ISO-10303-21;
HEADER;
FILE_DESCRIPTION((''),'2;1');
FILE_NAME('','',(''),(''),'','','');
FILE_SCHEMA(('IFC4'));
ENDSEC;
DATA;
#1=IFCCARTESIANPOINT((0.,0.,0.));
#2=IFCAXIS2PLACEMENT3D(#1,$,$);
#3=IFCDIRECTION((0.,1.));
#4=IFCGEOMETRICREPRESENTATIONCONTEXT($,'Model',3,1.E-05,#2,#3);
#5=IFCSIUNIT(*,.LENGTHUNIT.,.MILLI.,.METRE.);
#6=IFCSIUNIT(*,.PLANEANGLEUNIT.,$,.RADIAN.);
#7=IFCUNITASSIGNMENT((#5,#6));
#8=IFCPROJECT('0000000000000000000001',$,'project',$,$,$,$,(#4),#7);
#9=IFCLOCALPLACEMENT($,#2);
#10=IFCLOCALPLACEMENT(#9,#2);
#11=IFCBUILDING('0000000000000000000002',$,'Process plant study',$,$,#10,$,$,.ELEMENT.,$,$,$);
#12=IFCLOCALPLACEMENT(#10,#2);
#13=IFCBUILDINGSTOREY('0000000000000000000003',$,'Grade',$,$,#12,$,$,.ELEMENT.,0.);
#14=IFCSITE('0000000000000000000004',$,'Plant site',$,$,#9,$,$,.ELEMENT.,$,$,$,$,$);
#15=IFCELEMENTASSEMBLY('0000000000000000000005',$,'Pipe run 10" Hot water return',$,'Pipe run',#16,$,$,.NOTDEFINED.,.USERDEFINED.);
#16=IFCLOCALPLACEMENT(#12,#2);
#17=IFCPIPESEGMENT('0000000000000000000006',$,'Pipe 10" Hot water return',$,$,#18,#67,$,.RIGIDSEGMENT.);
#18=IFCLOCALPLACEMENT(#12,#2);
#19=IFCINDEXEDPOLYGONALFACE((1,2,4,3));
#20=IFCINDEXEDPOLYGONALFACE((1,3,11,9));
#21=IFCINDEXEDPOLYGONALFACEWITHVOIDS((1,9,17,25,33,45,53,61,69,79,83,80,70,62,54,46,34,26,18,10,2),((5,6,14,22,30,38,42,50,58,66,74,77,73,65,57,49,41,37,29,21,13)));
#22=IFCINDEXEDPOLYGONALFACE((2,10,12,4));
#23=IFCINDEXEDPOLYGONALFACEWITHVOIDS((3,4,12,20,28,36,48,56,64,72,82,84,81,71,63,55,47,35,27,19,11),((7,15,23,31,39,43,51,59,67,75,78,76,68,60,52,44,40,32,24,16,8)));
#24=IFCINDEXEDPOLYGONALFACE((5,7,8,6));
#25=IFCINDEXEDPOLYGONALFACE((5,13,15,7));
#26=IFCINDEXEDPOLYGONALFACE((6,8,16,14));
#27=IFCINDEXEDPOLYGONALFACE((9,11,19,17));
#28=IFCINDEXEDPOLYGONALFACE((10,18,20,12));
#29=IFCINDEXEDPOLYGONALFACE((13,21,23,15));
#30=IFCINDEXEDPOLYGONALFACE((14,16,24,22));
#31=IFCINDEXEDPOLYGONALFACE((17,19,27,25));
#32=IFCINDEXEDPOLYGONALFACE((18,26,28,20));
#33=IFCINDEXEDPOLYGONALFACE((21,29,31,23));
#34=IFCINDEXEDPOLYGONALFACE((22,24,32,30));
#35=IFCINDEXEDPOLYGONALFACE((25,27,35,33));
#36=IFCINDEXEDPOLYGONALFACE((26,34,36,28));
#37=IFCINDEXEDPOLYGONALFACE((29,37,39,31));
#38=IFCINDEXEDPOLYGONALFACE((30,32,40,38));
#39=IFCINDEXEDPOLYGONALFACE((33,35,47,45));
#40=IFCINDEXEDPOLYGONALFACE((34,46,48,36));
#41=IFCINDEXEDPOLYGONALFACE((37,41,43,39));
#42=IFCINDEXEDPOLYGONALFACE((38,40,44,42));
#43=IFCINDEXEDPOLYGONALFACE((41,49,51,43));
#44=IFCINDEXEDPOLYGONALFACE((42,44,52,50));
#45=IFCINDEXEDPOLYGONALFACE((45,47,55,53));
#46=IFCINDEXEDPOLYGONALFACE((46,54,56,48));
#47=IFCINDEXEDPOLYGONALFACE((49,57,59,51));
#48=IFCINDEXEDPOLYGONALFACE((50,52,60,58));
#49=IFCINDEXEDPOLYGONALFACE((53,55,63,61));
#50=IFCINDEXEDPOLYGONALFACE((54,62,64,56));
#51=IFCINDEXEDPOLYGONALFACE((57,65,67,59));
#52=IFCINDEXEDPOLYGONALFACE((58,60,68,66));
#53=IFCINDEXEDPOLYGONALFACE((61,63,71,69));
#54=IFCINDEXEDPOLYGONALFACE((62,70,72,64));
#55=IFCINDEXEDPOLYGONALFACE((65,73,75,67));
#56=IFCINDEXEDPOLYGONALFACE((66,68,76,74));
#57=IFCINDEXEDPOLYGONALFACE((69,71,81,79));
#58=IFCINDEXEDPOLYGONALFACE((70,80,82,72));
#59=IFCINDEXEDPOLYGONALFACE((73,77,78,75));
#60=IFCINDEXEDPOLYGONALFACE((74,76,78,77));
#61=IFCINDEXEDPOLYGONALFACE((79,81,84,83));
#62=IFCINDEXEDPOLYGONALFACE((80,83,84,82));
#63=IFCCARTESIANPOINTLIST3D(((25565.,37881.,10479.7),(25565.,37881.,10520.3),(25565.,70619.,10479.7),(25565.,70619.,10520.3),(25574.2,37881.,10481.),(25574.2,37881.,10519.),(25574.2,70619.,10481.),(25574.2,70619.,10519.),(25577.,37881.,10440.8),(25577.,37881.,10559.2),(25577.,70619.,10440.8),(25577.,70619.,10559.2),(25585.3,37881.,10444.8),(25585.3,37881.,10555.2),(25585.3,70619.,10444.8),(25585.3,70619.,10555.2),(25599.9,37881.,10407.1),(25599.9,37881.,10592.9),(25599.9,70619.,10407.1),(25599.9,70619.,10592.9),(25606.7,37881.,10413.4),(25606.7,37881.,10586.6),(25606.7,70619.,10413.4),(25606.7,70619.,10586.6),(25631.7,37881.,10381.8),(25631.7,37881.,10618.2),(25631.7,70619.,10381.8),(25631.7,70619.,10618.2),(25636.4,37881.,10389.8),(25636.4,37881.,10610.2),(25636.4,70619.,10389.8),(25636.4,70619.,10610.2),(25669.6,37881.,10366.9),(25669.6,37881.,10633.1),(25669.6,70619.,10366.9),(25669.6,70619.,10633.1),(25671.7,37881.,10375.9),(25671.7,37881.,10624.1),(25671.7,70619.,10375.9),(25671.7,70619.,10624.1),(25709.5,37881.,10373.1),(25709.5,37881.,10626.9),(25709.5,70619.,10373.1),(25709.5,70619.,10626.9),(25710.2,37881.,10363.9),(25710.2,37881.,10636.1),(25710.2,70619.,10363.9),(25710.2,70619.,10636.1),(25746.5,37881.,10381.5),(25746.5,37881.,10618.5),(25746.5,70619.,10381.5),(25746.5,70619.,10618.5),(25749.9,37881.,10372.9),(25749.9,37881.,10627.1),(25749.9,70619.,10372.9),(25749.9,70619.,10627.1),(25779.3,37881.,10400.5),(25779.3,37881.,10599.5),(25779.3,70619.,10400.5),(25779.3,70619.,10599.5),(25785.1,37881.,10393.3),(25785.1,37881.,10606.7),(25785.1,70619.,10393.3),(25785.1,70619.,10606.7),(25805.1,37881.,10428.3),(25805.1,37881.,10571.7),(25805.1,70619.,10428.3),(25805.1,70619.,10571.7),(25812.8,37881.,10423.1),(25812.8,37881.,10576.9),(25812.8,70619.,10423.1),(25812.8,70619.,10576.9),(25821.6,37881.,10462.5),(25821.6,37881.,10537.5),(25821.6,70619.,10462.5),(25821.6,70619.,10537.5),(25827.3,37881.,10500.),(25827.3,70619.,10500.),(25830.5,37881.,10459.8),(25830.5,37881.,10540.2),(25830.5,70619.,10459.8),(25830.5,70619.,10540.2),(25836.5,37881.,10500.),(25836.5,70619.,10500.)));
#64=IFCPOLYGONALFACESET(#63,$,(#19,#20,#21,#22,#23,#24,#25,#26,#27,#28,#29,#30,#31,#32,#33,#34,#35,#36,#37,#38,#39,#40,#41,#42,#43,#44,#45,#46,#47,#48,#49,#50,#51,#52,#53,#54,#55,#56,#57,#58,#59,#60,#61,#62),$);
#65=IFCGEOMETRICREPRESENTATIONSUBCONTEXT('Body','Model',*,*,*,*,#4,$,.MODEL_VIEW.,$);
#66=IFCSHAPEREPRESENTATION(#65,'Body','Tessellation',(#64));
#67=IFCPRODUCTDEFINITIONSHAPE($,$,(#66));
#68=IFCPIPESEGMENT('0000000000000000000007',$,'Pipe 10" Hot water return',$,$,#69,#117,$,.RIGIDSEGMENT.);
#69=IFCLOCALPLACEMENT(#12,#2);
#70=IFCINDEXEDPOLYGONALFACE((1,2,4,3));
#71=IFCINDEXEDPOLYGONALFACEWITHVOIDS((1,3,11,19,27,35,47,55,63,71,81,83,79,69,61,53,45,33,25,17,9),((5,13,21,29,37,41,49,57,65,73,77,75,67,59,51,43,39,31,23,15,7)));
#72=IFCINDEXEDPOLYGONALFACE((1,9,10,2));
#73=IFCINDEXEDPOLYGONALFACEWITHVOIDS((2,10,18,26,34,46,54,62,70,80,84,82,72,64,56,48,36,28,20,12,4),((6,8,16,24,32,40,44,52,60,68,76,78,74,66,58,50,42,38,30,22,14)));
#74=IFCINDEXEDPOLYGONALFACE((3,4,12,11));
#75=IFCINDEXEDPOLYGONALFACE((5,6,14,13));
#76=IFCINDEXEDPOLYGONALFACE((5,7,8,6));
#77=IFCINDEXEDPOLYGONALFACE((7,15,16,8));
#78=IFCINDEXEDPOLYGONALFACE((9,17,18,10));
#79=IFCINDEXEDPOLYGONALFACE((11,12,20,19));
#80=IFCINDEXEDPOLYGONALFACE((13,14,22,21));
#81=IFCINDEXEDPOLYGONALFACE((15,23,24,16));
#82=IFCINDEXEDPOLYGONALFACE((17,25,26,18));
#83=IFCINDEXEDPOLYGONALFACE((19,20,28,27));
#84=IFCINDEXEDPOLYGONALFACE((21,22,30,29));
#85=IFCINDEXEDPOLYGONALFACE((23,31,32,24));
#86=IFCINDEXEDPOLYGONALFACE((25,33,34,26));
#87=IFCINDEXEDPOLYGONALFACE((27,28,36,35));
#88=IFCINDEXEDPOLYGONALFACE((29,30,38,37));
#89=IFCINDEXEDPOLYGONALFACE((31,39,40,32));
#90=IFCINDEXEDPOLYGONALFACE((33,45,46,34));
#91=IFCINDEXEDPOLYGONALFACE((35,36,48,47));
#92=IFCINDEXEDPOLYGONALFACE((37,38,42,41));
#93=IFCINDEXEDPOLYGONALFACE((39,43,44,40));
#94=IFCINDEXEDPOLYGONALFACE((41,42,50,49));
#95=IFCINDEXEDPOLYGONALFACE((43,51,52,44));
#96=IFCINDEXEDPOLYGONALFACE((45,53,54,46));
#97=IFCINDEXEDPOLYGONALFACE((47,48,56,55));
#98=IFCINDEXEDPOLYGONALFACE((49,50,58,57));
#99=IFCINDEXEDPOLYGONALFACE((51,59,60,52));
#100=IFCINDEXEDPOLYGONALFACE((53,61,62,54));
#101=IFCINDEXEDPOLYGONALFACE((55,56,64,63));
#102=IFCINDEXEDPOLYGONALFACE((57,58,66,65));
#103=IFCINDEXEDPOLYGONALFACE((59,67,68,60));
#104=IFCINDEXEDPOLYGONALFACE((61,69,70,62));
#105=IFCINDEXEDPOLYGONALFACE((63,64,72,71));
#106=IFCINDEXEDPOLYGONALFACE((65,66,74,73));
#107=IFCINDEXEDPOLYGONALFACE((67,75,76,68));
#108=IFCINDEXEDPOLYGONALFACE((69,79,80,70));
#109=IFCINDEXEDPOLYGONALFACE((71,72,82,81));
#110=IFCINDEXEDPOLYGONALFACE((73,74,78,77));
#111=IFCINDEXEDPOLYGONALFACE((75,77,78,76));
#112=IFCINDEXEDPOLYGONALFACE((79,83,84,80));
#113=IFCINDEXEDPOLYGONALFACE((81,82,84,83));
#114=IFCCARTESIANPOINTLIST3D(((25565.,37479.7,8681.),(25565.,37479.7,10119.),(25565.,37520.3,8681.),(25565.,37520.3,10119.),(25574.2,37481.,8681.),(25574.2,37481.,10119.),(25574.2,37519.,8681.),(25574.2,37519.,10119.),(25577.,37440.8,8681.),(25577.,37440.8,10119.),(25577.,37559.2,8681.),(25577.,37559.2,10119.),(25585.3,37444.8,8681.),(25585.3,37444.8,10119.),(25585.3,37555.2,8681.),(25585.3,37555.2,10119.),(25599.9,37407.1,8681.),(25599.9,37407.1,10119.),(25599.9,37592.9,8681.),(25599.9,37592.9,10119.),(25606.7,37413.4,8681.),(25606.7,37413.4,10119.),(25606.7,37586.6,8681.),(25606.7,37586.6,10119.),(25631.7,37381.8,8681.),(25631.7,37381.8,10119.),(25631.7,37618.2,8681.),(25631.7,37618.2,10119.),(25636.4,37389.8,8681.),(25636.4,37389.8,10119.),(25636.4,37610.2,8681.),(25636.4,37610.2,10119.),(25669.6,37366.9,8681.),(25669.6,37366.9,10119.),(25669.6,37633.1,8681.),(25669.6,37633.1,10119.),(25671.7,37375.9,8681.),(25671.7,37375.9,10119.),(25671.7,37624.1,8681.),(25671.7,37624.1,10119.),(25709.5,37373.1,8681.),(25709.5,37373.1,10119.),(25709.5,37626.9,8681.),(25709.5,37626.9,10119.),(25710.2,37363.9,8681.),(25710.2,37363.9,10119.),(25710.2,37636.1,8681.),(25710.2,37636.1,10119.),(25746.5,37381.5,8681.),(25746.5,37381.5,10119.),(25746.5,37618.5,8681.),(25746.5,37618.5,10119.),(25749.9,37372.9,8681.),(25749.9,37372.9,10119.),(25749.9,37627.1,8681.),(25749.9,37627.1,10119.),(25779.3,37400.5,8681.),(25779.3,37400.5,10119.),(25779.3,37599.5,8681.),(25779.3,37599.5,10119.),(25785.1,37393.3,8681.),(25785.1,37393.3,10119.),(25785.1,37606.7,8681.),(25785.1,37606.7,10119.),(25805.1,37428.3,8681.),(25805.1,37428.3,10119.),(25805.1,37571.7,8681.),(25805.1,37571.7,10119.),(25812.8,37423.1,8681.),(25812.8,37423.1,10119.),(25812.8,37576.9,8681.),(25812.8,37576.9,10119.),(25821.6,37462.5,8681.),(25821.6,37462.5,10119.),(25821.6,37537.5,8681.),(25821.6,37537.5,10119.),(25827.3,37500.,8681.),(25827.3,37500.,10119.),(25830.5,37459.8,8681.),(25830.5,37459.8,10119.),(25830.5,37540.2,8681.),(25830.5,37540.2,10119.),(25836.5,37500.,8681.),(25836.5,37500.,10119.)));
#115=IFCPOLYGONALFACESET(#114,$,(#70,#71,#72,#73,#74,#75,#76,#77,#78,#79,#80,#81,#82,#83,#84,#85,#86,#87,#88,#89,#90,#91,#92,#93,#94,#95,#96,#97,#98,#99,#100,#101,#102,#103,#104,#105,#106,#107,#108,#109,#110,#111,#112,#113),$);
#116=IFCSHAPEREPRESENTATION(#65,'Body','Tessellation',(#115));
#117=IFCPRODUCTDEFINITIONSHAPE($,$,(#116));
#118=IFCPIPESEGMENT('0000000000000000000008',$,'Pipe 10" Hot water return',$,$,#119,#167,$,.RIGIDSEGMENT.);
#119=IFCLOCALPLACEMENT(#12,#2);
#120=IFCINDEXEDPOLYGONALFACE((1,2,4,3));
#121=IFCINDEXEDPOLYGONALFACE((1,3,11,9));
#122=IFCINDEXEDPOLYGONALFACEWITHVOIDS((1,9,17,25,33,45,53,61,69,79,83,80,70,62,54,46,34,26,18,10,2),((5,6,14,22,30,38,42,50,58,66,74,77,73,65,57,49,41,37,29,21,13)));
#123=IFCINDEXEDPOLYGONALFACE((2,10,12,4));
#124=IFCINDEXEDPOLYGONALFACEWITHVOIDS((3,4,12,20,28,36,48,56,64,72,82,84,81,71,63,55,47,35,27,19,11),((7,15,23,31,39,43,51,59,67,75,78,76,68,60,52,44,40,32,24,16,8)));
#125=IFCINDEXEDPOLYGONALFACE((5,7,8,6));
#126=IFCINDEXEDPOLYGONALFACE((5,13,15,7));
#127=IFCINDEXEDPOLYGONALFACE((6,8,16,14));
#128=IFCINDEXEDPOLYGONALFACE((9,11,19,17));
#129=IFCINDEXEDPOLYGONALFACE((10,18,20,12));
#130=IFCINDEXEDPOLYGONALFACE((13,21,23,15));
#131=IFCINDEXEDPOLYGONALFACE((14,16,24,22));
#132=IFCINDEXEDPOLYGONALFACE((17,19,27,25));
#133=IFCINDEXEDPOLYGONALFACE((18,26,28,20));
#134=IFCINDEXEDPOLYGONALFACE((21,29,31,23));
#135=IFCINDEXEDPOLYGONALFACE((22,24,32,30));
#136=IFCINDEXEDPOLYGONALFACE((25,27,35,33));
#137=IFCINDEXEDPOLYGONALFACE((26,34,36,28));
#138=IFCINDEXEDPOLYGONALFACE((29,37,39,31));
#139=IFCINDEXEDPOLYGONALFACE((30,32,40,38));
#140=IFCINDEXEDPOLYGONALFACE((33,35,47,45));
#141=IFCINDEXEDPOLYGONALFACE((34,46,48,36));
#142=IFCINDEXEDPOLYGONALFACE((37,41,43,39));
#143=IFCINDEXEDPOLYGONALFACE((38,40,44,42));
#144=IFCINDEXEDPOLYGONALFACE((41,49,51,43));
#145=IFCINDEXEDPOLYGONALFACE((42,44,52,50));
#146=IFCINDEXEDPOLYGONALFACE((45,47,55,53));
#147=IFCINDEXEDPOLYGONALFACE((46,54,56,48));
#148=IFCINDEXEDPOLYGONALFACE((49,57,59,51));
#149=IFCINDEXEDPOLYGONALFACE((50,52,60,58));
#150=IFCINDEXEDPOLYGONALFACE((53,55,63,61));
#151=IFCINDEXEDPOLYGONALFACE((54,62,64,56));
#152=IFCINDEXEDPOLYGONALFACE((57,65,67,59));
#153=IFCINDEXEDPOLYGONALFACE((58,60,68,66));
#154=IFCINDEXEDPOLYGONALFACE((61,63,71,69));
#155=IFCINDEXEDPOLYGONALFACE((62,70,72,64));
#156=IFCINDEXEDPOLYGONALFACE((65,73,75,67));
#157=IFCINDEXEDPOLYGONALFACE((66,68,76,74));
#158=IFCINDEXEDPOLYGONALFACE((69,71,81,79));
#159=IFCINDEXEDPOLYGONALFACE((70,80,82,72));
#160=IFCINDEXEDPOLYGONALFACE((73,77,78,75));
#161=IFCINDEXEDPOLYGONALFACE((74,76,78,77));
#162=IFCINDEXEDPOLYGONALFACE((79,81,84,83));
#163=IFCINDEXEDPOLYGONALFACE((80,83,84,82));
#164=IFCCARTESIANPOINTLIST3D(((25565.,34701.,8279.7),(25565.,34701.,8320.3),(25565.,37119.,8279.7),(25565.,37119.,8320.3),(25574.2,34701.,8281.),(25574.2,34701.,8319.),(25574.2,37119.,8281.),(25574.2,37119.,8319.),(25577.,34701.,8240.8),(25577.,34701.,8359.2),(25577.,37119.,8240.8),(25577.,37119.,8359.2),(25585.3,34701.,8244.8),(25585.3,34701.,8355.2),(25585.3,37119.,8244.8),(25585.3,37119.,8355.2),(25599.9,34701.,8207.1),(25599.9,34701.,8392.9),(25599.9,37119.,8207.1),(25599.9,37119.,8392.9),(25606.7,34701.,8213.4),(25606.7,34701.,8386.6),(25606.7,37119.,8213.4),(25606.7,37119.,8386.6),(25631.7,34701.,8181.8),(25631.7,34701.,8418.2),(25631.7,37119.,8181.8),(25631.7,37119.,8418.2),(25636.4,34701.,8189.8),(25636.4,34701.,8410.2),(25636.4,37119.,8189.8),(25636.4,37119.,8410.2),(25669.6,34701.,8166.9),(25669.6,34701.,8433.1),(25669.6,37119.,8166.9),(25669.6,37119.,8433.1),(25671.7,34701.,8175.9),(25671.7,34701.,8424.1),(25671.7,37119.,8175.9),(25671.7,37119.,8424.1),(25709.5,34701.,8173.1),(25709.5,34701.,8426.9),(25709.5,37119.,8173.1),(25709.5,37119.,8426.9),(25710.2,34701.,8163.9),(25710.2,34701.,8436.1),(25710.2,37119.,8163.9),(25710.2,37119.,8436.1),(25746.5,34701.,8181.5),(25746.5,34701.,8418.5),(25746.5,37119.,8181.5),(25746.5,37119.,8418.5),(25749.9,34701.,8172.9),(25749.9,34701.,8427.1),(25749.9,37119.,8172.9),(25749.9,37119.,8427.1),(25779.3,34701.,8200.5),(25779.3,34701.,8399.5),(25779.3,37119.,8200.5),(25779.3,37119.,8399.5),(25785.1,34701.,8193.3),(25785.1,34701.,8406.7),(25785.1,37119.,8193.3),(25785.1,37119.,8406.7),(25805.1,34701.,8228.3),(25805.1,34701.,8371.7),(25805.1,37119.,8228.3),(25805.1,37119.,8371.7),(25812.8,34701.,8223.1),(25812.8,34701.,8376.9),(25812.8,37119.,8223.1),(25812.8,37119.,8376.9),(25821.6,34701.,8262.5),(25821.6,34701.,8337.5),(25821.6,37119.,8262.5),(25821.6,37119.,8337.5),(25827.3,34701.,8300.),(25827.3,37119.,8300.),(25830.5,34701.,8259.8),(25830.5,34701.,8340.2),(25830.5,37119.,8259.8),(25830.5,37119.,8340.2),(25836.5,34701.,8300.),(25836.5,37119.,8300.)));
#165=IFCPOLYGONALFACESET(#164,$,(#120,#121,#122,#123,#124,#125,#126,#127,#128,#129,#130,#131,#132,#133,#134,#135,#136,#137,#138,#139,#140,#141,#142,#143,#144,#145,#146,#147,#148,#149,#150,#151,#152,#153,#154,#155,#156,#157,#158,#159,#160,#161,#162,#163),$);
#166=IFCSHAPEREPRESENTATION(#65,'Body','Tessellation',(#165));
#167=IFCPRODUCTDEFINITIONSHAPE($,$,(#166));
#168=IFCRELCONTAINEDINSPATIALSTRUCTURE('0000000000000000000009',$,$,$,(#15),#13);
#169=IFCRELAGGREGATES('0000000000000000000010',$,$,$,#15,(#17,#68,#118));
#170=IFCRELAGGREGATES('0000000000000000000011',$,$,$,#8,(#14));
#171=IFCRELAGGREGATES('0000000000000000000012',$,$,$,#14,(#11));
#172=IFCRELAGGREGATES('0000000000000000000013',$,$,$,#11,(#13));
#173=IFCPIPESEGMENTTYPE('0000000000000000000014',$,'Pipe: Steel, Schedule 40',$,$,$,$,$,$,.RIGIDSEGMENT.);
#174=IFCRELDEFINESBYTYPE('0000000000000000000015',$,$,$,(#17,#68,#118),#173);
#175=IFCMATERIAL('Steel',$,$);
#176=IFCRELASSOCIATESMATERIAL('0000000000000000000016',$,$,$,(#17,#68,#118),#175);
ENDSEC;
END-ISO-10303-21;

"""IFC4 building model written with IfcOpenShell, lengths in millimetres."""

from ifc_helpers import new_model, si_unit, direction, frame, origin, origin_with_axes, origin_2d, place, context, subcontext, project, spatial, hollow_circle, extrude, material, type_object, element, aggregate, save


model = new_model("IFC4")

# Units and contexts
model_context = context("Model", 3, precision=1e-05, world=origin(), true_north=direction((0.0, 1.0)))
body_context = subcontext(model_context, "Body", "Model", "MODEL_VIEW")
ifc_project = project(units=[si_unit("LENGTHUNIT", "METRE", prefix="MILLI"), si_unit("PLANEANGLEUNIT", "RADIAN")], contexts=[model_context])

# Site, building, storey
site_placement = place(None, origin())
site = spatial("IfcSite", under=ifc_project, at=site_placement, Name="Plant site", CompositionType="ELEMENT")
building_placement = place(site_placement, origin())
building = spatial("IfcBuilding", under=site, at=building_placement, Name="Process plant study", CompositionType="ELEMENT")
storey_placement = place(building_placement, origin())
storey = spatial("IfcBuildingStorey", under=building, at=storey_placement, Name="Grade", CompositionType="ELEMENT", Elevation=0.0)

# Shared definitions
ifc_material = material(Name="Steel")
pipe_segment_type = type_object("IfcPipeSegmentType", Name="Pipe: Steel, Schedule 40", PredefinedType="RIGIDSEGMENT")

# Element assembly, pipe segments
assembly_1_placement = place(storey_placement, origin_with_axes())
assembly_1 = element("IfcElementAssembly", 1, at=assembly_1_placement, inside=storey, Name="Pipe run 10\" Hot water return", ObjectType="Pipe run", AssemblyPlace="NOTDEFINED", PredefinedType="USERDEFINED")
pipe_segment_1_placement = place(storey_placement, origin_with_axes())
pipe_segment_1 = element("IfcPipeSegment", 2, at=pipe_segment_1_placement, type_object=pipe_segment_type, material=ifc_material, Name="Pipe 10\" Hot water return", PredefinedType="RIGIDSEGMENT", context=body_context, shape_type="SweptSolid", body=[
    extrude(hollow_circle(Radius=136.5, WallThickness=9.3, at=origin_2d()), frame((25700.0, 70619.0, 10500.0), z_axis=(0.0, -1.0, 0.0), x_axis=(1.0, 0.0, 0.0)), (0.0, 0.0, 1.0), 32738.0),
])
pipe_segment_2_placement = place(storey_placement, origin_with_axes())
pipe_segment_2 = element("IfcPipeSegment", 3, at=pipe_segment_2_placement, type_object=pipe_segment_type, material=ifc_material, Name="Pipe 10\" Hot water return", PredefinedType="RIGIDSEGMENT", context=body_context, shape_type="SweptSolid", body=[
    extrude(hollow_circle(Radius=136.5, WallThickness=9.3, at=origin_2d()), frame((25700.0, 37500.0, 10119.0), z_axis=(0.0, 0.0, -1.0), x_axis=(1.0, 0.0, 0.0)), (0.0, 0.0, 1.0), 1438.0),
])
pipe_segment_3_placement = place(storey_placement, origin_with_axes())
pipe_segment_3 = element("IfcPipeSegment", 4, at=pipe_segment_3_placement, type_object=pipe_segment_type, material=ifc_material, Name="Pipe 10\" Hot water return", PredefinedType="RIGIDSEGMENT", context=body_context, shape_type="SweptSolid", body=[
    extrude(hollow_circle(Radius=136.5, WallThickness=9.3, at=origin_2d()), frame((25700.0, 37119.0, 8300.0), z_axis=(0.0, -1.0, 0.0), x_axis=(1.0, 0.0, 0.0)), (0.0, 0.0, 1.0), 2418.0),
])

aggregate(assembly_1, [pipe_segment_1, pipe_segment_2, pipe_segment_3])

save(model, "model.ifc")
